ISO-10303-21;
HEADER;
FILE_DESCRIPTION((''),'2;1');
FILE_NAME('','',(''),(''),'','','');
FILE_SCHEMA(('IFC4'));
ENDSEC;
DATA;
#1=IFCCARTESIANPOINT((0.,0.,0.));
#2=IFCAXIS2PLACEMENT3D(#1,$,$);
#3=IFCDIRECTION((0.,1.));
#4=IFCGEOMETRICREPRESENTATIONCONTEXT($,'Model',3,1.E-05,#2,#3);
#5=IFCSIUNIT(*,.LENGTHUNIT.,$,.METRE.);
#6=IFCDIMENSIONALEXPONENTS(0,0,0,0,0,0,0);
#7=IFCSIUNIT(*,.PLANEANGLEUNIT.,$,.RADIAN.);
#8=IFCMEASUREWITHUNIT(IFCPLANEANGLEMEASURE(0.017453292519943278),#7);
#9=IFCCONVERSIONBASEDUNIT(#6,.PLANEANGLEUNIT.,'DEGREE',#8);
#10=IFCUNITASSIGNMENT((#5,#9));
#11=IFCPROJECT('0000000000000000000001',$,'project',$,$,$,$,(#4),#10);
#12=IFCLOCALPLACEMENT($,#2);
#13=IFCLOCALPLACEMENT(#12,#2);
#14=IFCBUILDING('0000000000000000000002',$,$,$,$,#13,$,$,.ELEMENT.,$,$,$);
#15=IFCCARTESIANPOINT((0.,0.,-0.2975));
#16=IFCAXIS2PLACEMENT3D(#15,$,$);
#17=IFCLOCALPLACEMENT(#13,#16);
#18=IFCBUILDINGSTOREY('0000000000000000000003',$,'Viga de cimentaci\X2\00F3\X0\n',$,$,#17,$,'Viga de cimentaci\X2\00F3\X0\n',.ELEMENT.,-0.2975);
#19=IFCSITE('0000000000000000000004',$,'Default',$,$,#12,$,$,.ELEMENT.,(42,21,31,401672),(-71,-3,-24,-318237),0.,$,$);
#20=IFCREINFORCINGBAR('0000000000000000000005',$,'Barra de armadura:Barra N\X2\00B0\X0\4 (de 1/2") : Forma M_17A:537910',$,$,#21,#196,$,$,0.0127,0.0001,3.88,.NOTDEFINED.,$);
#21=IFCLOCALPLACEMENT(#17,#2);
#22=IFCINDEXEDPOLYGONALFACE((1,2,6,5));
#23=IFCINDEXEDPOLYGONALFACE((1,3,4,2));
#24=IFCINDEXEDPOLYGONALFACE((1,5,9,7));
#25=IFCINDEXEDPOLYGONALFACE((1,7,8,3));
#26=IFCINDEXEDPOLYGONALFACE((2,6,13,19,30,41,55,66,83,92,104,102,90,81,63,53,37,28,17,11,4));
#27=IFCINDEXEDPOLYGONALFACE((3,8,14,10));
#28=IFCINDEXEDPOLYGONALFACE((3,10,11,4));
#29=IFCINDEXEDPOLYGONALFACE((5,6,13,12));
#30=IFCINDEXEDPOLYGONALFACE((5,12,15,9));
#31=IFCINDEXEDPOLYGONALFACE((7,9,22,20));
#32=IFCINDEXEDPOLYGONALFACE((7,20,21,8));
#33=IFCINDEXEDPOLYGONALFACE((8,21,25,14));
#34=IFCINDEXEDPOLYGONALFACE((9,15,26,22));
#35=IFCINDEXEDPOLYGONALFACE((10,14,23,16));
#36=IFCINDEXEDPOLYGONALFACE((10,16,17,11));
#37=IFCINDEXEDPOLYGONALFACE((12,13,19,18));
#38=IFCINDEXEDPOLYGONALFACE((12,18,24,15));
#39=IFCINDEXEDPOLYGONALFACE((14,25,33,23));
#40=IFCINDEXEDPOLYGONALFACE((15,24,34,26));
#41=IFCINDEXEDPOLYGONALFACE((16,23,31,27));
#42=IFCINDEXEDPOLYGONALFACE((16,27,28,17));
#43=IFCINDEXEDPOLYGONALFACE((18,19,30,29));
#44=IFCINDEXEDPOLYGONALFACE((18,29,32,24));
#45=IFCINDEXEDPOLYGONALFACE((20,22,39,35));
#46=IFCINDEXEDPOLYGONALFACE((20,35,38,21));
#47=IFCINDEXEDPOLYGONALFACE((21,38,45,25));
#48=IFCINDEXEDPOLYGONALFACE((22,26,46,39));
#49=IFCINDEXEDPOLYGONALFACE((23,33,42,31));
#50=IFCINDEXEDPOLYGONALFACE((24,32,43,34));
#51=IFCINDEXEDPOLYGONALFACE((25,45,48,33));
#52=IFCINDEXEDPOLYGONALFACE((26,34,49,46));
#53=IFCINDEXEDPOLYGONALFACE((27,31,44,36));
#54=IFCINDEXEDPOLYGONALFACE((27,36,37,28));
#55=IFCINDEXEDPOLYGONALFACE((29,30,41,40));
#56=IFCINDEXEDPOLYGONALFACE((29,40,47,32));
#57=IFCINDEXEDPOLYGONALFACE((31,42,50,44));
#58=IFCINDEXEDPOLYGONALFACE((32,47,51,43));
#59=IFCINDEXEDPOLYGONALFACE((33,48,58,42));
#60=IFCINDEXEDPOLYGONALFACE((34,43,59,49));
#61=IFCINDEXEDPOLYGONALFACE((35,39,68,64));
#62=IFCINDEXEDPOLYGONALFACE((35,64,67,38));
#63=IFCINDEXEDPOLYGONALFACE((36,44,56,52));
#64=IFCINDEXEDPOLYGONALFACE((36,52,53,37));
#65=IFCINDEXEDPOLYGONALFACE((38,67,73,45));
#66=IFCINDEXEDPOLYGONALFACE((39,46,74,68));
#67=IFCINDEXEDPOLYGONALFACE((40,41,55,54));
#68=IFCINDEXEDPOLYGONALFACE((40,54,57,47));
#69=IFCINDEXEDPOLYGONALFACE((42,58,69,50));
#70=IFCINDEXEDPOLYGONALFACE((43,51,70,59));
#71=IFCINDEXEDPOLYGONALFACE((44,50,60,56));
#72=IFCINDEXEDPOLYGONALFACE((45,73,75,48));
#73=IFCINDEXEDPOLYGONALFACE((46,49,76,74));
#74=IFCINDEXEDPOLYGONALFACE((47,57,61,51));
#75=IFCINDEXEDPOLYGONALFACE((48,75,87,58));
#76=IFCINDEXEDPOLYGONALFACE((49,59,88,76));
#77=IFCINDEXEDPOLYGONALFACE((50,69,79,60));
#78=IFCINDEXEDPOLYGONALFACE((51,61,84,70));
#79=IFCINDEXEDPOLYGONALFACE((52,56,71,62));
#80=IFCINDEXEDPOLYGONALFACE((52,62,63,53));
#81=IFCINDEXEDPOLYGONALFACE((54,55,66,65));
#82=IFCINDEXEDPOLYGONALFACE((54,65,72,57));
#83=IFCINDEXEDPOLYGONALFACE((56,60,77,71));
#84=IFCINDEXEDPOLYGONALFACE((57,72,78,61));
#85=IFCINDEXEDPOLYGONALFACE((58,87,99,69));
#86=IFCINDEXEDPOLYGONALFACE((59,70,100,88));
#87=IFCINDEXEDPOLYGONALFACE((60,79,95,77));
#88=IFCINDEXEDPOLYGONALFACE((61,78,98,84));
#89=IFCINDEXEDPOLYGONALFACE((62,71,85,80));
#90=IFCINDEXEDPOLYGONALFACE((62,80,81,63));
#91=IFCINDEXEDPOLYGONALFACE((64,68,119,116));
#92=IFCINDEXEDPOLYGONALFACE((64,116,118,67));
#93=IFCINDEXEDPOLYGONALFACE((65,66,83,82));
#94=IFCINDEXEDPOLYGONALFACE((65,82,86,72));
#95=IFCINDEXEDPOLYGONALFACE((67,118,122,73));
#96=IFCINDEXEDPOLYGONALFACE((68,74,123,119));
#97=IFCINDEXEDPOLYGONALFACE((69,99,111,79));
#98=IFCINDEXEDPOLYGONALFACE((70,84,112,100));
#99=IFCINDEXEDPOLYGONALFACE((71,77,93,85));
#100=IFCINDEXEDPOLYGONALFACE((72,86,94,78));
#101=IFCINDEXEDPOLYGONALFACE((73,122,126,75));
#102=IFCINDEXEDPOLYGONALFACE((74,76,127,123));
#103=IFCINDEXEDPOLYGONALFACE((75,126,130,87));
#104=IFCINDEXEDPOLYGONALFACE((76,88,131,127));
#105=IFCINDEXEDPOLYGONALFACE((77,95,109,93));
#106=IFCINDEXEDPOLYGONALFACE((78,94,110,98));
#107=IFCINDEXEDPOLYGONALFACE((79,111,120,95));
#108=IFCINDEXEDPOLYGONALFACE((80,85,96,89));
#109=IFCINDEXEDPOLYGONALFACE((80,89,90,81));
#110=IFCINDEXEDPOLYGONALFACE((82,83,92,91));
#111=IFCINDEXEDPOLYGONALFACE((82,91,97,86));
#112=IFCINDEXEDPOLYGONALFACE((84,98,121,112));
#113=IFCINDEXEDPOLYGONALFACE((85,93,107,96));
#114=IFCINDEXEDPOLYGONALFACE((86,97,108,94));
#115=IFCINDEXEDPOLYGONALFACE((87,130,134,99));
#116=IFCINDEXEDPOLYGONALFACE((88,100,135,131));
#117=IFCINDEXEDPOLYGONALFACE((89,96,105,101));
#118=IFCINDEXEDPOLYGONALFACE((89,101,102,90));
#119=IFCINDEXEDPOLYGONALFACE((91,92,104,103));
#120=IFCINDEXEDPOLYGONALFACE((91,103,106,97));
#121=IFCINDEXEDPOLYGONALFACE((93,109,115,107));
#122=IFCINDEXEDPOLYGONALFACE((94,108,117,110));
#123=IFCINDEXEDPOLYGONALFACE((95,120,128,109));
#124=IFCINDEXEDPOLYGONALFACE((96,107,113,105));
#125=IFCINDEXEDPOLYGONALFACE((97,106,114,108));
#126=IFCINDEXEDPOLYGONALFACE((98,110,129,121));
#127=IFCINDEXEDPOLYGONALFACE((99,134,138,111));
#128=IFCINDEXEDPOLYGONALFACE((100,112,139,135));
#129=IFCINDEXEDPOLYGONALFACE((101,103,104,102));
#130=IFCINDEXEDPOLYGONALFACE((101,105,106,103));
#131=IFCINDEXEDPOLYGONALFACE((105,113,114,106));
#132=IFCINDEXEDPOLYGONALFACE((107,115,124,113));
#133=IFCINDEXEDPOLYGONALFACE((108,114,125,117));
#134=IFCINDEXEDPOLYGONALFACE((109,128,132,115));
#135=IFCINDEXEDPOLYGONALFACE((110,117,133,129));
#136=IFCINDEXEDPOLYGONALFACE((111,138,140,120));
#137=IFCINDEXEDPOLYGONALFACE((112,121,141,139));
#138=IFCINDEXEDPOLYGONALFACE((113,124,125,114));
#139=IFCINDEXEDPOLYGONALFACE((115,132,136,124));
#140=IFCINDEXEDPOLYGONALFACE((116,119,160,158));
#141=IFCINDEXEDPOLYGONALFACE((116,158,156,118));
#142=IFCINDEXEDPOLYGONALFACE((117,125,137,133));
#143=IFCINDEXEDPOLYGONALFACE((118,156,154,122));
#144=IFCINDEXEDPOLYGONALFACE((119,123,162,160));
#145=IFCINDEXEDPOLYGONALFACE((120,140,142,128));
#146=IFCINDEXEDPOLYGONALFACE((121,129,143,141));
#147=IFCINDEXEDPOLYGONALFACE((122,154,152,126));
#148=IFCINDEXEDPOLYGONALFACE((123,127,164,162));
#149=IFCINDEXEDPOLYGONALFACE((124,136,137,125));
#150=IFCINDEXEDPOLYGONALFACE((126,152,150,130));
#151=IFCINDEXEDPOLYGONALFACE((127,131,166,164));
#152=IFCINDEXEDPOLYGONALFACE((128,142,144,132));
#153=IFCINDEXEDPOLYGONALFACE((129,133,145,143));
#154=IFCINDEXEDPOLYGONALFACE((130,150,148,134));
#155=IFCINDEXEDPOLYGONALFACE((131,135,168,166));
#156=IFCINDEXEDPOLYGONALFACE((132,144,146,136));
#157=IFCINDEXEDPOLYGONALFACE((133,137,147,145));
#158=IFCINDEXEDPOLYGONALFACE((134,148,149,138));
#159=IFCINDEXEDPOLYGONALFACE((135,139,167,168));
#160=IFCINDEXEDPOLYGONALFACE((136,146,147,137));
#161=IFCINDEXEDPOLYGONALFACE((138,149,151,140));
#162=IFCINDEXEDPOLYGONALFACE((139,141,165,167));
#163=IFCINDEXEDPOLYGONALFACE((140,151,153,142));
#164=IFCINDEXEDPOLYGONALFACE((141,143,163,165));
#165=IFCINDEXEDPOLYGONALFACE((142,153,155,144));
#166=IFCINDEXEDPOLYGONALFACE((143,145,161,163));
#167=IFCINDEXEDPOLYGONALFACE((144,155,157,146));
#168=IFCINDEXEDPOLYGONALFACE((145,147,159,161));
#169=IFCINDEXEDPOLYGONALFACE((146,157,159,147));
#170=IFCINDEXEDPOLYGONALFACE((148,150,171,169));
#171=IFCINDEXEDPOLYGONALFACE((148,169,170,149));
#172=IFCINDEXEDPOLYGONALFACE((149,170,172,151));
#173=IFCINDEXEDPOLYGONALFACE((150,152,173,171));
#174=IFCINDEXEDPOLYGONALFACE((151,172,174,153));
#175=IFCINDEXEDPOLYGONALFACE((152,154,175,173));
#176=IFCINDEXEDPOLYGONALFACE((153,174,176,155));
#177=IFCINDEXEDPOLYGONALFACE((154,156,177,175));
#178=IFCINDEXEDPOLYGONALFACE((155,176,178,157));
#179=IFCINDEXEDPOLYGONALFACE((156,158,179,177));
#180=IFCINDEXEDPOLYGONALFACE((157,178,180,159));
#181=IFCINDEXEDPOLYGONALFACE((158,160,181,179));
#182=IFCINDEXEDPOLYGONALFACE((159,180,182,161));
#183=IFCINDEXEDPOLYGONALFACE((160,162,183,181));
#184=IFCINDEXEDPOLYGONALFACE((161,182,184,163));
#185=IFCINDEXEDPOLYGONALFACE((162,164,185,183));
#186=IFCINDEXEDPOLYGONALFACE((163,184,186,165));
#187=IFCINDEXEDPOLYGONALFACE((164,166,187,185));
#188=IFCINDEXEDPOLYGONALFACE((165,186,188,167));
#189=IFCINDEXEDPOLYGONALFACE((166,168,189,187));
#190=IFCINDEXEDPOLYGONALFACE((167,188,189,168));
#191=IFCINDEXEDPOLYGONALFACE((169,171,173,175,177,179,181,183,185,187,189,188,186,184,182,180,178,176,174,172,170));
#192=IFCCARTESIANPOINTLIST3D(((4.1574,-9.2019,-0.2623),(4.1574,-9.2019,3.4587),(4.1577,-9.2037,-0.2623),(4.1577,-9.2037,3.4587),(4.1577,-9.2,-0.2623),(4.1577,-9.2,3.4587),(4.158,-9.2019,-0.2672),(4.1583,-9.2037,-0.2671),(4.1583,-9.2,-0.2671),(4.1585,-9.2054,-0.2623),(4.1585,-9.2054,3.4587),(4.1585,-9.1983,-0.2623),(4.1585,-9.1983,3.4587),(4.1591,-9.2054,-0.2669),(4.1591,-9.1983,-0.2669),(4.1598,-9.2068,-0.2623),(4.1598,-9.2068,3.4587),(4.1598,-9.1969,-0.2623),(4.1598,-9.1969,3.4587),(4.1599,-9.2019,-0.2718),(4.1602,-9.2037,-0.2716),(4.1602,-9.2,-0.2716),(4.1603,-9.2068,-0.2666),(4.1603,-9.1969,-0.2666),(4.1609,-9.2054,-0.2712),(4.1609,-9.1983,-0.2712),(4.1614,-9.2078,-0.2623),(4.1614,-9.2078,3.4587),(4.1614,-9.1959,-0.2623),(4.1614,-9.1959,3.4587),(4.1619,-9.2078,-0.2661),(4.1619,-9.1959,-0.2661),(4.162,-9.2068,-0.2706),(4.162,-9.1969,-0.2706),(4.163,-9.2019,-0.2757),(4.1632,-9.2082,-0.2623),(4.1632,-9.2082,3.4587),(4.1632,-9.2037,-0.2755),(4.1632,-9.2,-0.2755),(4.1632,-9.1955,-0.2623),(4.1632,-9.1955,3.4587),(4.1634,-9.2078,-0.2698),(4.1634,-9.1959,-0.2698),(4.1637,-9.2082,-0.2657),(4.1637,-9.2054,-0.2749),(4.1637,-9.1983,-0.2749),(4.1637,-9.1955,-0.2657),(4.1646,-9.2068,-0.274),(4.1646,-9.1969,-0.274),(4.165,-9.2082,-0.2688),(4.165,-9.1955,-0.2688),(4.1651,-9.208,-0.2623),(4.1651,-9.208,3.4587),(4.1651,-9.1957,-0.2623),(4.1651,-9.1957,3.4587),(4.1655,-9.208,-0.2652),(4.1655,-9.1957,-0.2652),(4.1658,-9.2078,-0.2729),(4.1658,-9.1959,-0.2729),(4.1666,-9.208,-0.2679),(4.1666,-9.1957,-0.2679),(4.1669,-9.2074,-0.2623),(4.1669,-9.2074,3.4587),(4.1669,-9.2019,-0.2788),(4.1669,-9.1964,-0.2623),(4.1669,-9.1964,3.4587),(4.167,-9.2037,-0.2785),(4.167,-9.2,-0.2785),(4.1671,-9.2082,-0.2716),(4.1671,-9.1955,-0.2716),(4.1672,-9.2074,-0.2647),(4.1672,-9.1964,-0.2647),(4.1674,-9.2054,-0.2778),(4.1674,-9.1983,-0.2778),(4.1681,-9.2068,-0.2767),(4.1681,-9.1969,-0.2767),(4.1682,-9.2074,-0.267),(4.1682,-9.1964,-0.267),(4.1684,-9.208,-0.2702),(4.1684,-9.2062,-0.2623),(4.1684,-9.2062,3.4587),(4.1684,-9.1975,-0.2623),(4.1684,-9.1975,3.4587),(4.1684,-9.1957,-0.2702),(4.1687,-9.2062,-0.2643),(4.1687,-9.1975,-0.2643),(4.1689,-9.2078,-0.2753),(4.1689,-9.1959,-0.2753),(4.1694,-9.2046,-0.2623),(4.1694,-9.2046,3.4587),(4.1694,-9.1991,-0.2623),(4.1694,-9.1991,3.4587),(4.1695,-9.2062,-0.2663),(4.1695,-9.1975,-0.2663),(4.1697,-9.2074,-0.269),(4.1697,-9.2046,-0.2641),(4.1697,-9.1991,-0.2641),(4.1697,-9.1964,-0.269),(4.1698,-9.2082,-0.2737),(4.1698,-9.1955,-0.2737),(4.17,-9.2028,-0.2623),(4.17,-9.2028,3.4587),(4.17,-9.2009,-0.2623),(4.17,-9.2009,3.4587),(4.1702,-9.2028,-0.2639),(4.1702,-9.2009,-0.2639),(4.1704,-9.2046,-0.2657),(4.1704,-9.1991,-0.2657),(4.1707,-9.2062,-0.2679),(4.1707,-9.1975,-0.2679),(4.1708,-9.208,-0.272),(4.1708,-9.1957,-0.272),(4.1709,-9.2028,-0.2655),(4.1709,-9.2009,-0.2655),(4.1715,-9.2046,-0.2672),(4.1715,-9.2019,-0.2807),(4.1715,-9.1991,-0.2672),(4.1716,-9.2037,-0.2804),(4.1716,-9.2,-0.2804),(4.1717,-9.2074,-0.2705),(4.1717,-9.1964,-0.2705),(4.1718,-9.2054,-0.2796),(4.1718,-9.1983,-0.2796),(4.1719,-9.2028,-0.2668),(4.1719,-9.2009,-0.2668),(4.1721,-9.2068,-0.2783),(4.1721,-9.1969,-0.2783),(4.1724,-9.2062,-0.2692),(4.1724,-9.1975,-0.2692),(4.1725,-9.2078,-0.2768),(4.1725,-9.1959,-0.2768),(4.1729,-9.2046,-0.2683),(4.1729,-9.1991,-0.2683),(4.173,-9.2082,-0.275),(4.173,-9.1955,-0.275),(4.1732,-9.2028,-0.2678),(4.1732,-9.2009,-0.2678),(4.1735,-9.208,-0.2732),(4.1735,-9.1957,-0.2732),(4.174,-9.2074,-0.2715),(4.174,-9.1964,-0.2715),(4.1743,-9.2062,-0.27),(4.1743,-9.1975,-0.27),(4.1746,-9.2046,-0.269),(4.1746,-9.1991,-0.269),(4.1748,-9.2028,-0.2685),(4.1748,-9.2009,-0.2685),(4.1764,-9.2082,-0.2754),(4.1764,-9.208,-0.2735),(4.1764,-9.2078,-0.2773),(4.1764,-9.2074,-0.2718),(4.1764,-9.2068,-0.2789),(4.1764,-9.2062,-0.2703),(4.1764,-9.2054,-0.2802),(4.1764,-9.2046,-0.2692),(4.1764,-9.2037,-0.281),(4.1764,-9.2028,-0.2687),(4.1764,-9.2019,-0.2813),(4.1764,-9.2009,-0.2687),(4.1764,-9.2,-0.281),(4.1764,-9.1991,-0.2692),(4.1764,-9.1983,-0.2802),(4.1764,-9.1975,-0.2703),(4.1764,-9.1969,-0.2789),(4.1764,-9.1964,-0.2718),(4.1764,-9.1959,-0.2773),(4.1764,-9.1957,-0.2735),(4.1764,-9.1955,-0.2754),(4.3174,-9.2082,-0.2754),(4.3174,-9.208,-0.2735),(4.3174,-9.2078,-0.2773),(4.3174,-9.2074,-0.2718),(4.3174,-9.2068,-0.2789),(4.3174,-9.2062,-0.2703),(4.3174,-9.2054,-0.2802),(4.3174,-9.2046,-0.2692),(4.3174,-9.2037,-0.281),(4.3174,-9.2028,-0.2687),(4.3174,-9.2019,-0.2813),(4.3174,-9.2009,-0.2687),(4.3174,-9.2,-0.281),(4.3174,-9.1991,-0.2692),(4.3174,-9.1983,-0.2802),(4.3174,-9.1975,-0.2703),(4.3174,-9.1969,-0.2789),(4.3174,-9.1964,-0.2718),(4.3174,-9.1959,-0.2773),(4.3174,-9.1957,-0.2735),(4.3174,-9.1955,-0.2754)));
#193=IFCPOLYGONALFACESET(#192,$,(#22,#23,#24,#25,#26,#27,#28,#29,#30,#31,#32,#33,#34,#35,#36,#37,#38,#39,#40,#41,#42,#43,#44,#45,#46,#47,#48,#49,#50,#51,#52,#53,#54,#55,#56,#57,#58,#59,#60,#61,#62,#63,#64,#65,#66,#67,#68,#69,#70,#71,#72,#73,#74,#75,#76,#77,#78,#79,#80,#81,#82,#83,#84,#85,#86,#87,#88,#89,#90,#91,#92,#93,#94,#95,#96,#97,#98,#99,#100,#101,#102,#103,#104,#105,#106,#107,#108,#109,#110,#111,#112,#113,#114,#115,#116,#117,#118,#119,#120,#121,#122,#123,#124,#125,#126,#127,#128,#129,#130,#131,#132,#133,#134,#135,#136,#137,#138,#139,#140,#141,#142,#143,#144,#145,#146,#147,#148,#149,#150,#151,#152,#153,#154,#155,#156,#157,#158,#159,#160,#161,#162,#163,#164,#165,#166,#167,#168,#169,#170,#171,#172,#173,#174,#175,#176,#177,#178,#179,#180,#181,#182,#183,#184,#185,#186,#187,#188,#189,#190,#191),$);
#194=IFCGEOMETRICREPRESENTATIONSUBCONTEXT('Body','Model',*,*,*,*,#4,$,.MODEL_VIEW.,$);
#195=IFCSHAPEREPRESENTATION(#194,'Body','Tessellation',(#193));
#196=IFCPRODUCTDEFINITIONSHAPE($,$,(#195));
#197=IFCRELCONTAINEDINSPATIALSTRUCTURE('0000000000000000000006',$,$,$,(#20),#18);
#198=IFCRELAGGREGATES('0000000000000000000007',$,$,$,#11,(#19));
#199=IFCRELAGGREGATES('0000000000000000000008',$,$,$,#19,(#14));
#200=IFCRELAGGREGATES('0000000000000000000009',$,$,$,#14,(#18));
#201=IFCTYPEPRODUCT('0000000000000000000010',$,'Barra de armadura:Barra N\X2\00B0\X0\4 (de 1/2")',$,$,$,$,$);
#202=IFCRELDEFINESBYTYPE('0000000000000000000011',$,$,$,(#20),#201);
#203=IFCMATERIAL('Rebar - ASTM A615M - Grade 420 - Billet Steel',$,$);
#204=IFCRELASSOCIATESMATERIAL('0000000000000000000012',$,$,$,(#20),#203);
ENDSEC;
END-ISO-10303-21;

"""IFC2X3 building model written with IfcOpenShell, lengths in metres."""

from ifc_helpers import new_model, entity, si_unit, converted_unit, direction, frame, origin, place, context, subcontext, project, spatial, material, type_object, element, save


model = new_model("IFC2X3")

# Units and contexts
model_context = context("Model", 3, precision=1e-05, world=origin(), true_north=direction((0.0, 1.0)))
body_context = subcontext(model_context, "Body", "Model", "MODEL_VIEW")
ifc_project = project(units=[si_unit("LENGTHUNIT", "METRE"), converted_unit("PLANEANGLEUNIT", "DEGREE", entity("IfcPlaneAngleMeasure", 0.017453292519943278), si_unit("PLANEANGLEUNIT", "RADIAN"), dimensions=[0, 0, 0, 0, 0, 0, 0])], contexts=[model_context])

# Site, building, storey
site_placement = place(None, origin())
site = spatial("IfcSite", under=ifc_project, at=site_placement, Name="Default", CompositionType="ELEMENT", RefLatitude=(42, 21, 31, 401672), RefLongitude=(-71, -3, -24, -318237), RefElevation=0.0)
building_placement = place(site_placement, origin())
building = spatial("IfcBuilding", under=site, at=building_placement, CompositionType="ELEMENT")
storey_placement = place(building_placement, frame((0.0, 0.0, -0.2975)))
storey = spatial("IfcBuildingStorey", under=building, at=storey_placement, Name="Viga de cimentación", LongName="Viga de cimentación", CompositionType="ELEMENT", Elevation=-0.2975)

# Reinforcing bar
ifc_material_1 = material(Name="Rebar - ASTM A615M - Grade 420 - Billet Steel")
type_product_1 = type_object("IfcTypeProduct", Name="Barra de armadura:Barra N°4 (de 1/2\")")
reinforcing_bar_1_placement = place(storey_placement, origin())
element("IfcReinforcingBar", 1, at=reinforcing_bar_1_placement, inside=storey, type_object=type_product_1, material=ifc_material_1, Name="Barra de armadura:Barra N°4 (de 1/2\") : Forma M_17A:537910", BarLength=3.88, BarRole="NOTDEFINED", CrossSectionArea=0.0001, NominalDiameter=0.0127, context=body_context, shape_type="AdvancedSweptSolid", body=[
    entity("IfcSweptDiskSolid", entity("IfcCompositeCurve", [entity("IfcCompositeCurveSegment", "CONTINUOUS", True, entity("IfcPolyline", [entity("IfcCartesianPoint", [4.1637, -9.2019, 3.4587]), entity("IfcCartesianPoint", [4.1637, -9.2019, -0.2623])])), entity("IfcCompositeCurveSegment", "CONTINUOUS", True, entity("IfcTrimmedCurve", entity("IfcCircle", entity("IfcAxis2Placement3D", entity("IfcCartesianPoint", [4.1764, -9.2019, -0.2623]), entity("IfcDirection", [0.0, -1.0, 0.0]), entity("IfcDirection", [0.0, 0.0, -1.0])), 0.0127), [entity("IfcParameterValue", 270.0)], [entity("IfcParameterValue", 360.0)], True, "PARAMETER")), entity("IfcCompositeCurveSegment", "CONTINUOUS", True, entity("IfcPolyline", [entity("IfcCartesianPoint", [4.1764, -9.2019, -0.275]), entity("IfcCartesianPoint", [4.3174, -9.2019, -0.275])]))], False), 0.0063, None, 0.0, 92.0),
])

save(model, "model.ifc")
